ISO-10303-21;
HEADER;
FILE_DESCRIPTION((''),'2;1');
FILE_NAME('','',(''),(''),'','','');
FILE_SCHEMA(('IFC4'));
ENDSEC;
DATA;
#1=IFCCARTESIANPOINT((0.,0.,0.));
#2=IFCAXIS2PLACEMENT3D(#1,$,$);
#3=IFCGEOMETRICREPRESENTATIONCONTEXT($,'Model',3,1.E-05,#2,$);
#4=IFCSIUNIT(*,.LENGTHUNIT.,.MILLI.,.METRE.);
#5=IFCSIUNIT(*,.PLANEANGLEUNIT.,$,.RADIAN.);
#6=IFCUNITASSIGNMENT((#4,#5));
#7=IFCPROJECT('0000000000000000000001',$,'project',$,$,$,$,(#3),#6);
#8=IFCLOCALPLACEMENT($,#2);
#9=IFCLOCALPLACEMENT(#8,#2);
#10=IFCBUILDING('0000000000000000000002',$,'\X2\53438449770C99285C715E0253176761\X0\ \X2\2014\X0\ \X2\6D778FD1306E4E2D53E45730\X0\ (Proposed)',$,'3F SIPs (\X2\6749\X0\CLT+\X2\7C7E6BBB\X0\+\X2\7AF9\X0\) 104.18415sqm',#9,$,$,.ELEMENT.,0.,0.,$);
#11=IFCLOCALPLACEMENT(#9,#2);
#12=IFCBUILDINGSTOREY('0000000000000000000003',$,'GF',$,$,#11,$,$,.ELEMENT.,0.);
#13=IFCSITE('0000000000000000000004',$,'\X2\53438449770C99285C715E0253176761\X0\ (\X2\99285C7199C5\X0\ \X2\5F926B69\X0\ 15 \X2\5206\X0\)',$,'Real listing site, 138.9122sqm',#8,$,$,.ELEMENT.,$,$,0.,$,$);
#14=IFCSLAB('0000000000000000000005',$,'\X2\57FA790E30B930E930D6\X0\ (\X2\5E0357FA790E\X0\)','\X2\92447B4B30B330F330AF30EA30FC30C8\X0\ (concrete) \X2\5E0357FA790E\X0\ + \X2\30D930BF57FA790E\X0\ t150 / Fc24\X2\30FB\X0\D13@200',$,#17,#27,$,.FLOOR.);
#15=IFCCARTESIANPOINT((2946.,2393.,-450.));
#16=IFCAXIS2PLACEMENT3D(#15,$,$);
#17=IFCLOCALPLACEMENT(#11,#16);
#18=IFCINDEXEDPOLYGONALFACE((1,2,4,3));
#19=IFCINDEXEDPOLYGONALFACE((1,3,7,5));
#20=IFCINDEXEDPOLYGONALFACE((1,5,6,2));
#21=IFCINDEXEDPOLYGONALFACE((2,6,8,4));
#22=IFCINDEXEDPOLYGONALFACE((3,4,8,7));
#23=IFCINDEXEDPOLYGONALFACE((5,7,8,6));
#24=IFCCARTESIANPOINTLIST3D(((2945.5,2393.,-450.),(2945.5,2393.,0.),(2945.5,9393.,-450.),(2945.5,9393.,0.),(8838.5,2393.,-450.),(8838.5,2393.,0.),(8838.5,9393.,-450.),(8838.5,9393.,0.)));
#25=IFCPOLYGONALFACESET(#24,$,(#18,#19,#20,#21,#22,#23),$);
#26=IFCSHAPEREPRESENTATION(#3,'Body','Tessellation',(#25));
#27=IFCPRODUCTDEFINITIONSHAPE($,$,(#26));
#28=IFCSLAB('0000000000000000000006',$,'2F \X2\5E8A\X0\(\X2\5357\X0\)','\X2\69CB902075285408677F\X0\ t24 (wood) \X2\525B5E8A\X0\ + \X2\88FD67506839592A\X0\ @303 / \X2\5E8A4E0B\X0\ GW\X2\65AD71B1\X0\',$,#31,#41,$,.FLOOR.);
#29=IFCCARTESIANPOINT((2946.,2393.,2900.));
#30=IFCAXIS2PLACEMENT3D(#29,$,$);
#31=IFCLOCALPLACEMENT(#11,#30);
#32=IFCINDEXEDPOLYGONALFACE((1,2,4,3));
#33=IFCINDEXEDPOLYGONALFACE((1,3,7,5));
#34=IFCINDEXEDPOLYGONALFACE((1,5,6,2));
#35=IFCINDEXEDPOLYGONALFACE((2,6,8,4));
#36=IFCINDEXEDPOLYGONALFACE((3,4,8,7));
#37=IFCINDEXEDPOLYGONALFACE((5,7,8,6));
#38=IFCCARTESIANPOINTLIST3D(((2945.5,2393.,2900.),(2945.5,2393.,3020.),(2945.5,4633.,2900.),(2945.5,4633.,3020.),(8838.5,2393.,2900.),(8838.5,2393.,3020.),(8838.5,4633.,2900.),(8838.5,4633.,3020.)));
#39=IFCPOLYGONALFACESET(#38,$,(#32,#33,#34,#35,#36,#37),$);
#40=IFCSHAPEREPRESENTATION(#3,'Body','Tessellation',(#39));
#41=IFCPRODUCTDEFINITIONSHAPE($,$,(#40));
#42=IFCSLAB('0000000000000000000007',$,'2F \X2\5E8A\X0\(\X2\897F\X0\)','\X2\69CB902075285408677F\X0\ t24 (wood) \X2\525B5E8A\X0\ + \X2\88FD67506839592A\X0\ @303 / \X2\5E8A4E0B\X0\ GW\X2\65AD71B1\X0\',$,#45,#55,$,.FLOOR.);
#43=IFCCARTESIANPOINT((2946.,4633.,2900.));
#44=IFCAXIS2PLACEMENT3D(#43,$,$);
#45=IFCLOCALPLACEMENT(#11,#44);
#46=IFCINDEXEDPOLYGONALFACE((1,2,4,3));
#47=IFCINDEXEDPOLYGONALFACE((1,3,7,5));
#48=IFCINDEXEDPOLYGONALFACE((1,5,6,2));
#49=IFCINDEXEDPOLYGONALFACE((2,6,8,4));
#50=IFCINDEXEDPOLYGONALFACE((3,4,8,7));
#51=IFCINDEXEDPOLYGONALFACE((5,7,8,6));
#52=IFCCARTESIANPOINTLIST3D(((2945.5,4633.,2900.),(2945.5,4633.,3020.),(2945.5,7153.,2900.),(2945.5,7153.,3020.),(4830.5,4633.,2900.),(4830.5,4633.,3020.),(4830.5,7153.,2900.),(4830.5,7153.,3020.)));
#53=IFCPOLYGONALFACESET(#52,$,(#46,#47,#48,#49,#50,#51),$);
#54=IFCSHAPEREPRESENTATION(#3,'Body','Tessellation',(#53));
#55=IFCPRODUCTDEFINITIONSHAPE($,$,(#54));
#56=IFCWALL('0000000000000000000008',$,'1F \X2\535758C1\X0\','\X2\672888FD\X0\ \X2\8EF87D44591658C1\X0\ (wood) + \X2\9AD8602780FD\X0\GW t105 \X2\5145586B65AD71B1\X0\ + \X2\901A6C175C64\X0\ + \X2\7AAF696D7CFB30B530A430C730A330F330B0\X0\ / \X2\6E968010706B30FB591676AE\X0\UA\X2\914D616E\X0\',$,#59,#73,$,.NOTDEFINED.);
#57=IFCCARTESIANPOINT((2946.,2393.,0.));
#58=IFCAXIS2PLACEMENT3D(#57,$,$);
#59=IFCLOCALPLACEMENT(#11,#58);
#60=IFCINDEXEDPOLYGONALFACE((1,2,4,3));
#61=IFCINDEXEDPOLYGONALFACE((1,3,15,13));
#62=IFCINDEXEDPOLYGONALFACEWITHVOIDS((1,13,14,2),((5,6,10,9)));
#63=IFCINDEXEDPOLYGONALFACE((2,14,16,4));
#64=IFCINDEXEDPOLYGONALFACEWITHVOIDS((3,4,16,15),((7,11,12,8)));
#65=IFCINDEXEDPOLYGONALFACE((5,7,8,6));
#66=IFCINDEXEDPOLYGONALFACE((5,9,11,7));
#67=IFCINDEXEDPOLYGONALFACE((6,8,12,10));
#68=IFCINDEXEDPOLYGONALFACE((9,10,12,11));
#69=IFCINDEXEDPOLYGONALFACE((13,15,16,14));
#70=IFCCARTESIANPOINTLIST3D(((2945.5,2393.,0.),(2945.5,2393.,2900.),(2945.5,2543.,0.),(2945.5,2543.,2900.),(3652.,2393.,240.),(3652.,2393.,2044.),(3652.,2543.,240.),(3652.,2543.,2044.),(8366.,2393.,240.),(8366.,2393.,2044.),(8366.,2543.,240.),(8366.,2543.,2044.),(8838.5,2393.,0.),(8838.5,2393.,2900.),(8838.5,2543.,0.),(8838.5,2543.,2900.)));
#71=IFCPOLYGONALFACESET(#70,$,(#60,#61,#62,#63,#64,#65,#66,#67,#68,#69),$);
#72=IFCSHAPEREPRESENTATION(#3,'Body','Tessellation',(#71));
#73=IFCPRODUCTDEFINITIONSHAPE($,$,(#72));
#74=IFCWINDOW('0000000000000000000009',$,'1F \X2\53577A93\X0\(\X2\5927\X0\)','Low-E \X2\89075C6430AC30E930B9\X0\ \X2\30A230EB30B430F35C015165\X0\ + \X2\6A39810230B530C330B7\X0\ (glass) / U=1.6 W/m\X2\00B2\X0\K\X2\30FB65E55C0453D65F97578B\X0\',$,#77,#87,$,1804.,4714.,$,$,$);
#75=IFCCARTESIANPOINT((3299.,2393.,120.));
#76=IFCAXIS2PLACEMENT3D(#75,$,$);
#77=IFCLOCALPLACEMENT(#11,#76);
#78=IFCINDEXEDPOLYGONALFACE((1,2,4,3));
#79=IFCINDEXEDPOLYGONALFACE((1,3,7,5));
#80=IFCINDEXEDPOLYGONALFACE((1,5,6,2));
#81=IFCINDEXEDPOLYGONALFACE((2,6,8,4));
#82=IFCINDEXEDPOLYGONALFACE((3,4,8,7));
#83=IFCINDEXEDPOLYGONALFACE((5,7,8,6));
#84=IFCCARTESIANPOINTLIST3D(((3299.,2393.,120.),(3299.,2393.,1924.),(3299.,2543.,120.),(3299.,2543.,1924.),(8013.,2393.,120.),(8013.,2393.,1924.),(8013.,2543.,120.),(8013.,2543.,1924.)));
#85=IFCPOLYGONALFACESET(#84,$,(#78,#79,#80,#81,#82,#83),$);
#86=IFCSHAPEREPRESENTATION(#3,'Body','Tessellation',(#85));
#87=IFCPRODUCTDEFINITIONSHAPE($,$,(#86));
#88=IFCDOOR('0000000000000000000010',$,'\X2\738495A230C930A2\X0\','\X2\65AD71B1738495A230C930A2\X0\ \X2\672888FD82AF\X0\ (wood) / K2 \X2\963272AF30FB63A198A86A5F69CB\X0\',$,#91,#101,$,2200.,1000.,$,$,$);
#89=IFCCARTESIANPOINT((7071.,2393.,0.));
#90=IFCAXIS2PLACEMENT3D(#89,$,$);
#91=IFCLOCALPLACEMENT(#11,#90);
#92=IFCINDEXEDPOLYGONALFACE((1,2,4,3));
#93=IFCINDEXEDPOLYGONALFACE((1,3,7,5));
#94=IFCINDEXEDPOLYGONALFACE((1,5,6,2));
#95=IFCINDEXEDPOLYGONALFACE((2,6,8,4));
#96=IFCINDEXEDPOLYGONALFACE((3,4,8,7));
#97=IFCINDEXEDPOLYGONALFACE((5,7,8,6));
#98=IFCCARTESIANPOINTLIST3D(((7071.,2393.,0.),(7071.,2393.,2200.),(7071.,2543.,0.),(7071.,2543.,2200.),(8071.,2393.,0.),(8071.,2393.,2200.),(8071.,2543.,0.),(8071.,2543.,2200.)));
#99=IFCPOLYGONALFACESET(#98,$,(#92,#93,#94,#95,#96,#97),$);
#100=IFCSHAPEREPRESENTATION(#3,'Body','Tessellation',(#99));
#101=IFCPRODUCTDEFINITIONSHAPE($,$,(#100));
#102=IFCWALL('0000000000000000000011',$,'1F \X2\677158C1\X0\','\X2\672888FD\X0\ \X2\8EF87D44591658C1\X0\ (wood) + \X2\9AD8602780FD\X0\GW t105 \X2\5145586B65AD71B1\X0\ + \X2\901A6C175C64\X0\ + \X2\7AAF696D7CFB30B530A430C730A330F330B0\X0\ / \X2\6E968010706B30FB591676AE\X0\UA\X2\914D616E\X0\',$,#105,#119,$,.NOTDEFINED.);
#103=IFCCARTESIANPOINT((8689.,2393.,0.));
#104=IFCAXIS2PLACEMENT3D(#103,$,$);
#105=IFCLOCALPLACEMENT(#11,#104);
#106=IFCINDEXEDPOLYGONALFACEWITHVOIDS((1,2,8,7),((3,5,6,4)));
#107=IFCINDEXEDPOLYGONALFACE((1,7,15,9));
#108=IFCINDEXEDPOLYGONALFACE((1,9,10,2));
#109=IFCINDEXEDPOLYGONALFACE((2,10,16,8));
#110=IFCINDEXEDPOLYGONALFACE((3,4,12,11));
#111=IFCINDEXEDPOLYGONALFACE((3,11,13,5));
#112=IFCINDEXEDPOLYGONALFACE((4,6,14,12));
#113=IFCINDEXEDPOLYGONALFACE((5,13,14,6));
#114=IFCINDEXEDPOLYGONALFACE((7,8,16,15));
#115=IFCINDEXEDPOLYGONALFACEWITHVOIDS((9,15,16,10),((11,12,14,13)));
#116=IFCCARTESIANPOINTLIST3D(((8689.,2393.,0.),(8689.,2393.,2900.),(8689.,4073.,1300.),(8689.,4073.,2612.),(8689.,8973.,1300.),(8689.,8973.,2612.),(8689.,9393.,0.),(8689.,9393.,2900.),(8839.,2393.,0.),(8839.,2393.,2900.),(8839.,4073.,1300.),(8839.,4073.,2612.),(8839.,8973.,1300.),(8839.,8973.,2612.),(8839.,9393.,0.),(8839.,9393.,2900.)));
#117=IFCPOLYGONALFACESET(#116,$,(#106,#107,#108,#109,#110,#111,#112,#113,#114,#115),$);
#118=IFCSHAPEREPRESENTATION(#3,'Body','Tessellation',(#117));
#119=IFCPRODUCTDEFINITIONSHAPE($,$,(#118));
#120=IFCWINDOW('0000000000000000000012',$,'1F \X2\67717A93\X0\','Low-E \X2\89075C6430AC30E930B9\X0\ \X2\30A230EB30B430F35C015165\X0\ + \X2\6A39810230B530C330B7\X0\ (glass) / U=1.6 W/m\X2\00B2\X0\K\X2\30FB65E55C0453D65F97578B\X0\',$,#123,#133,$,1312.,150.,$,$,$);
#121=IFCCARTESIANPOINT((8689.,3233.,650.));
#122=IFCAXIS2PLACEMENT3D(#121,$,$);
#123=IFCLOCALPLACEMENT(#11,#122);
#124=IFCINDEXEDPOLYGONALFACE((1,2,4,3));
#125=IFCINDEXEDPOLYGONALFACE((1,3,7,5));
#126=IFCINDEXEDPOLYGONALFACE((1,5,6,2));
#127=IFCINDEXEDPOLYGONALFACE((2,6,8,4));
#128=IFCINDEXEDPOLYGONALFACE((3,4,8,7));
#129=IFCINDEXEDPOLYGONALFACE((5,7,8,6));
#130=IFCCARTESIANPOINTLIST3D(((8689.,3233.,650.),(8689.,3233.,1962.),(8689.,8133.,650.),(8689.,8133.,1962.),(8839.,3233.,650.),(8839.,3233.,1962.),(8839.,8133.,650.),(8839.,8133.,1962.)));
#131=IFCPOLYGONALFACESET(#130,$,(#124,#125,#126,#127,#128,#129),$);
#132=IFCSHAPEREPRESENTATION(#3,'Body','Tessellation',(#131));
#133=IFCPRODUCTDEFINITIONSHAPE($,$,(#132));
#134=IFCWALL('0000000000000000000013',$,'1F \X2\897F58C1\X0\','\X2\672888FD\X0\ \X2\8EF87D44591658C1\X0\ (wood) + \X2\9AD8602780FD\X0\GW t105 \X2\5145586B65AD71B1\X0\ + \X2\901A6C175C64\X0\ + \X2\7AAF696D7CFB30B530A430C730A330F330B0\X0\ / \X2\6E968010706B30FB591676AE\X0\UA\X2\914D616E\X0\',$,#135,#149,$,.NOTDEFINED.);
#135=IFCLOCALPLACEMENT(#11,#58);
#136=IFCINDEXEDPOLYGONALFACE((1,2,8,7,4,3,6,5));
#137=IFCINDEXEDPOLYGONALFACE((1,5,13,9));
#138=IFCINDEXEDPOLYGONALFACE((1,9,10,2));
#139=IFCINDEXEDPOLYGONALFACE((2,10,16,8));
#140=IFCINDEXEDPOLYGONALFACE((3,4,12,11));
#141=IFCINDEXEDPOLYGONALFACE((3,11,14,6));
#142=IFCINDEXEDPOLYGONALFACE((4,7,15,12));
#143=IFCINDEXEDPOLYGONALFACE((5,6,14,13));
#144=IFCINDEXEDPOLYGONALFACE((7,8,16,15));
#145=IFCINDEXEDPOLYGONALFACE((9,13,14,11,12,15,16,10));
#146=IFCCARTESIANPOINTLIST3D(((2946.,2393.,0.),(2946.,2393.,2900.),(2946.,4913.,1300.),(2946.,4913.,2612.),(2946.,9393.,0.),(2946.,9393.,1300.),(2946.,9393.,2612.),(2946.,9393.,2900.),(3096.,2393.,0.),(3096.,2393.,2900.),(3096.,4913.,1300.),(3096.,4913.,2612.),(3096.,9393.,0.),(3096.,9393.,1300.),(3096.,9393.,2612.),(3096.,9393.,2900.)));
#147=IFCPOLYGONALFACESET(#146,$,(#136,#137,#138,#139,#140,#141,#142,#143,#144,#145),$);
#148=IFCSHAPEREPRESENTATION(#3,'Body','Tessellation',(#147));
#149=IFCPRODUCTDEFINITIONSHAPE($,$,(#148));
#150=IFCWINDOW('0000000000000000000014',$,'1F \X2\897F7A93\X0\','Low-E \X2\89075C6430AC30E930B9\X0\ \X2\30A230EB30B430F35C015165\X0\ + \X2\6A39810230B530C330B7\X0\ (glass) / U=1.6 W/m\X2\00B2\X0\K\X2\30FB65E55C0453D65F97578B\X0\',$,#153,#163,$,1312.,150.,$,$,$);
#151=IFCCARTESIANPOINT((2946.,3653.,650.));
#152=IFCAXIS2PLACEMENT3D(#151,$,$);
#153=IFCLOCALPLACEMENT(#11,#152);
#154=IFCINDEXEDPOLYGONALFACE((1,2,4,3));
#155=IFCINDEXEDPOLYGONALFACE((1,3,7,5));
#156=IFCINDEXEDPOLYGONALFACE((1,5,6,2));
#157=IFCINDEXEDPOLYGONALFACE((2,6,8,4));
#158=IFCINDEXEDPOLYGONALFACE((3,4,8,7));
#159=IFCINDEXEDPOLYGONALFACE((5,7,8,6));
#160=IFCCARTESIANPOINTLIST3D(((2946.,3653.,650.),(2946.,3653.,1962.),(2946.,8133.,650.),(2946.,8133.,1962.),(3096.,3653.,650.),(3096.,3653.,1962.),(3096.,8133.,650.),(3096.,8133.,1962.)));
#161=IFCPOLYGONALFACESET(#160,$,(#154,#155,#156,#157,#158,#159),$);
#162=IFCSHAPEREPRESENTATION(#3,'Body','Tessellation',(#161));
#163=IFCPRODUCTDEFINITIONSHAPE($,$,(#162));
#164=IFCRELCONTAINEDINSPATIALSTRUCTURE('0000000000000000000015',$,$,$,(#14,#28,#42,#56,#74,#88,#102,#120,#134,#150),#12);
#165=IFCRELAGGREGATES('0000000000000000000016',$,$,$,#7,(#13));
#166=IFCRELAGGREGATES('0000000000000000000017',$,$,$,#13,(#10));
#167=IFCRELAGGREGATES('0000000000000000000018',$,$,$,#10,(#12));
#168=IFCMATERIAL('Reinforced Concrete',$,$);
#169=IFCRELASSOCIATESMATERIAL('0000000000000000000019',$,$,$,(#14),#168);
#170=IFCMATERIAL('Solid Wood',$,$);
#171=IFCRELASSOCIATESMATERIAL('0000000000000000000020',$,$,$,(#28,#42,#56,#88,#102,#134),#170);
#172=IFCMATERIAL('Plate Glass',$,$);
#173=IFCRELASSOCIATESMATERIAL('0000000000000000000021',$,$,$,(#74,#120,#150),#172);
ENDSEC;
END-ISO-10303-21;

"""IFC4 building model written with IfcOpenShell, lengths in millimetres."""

from ifc_helpers import new_model, si_unit, frame, frame_2d, origin, place, context, project, spatial, rectangle, extrude, material, element, fill, save


model = new_model("IFC4")

# Units and contexts
model_context = context("Model", 3, precision=1e-05, world=origin())
ifc_project = project(units=[si_unit("LENGTHUNIT", "METRE", prefix="MILLI"), si_unit("PLANEANGLEUNIT", "RADIAN")], contexts=[model_context])

# Site, building, storey
site_placement = place(None, origin())
site = spatial("IfcSite", under=ifc_project, at=site_placement, Name="千葉県館山市北条 (館山駅 徒歩 15 分)", ObjectType="Real listing site, 138.9122sqm", CompositionType="ELEMENT", RefElevation=0.0)
building_placement = place(site_placement, origin())
building = spatial("IfcBuilding", under=site, at=building_placement, Name="千葉県館山市北条 — 海近の中古地 (Proposed)", ObjectType="3F SIPs (杉CLT+籾殻+竹) 104.18415sqm", CompositionType="ELEMENT", ElevationOfRefHeight=0.0, ElevationOfTerrain=0.0)
storey_placement = place(building_placement, origin())
storey = spatial("IfcBuildingStorey", under=building, at=storey_placement, Name="GF", CompositionType="ELEMENT", Elevation=0.0)

# Slabs
ifc_material_1 = material(Name="Reinforced Concrete")
slab_1_placement = place(storey_placement, frame((2946.0, 2393.0, -450.0)))
element("IfcSlab", 1, at=slab_1_placement, inside=storey, material=ifc_material_1, Name="基礎スラブ (布基礎)", Description="鉄筋コンクリート (concrete) 布基礎 + ベタ基礎 t150 / Fc24・D13@200", PredefinedType="FLOOR", context=model_context, shape_type="SweptSolid", body=[
    extrude(rectangle(XDim=5893.0, YDim=7000.0, at=frame_2d((2946.0, 3500.0))), frame((2946.0, 2393.0, -450.0)), (0.0, 0.0, 1.0), 450.0),
])
ifc_material_2 = material(Name="Solid Wood")
slab_2_placement = place(storey_placement, frame((2946.0, 2393.0, 2900.0)))
element("IfcSlab", 2, at=slab_2_placement, inside=storey, material=ifc_material_2, Name="2F 床(南)", Description="構造用合板 t24 (wood) 剛床 + 製材根太 @303 / 床下 GW断熱", PredefinedType="FLOOR", context=model_context, shape_type="SweptSolid", body=[
    extrude(rectangle(XDim=5893.0, YDim=2240.0, at=frame_2d((2946.0, 1120.0))), frame((2946.0, 2393.0, 2900.0)), (0.0, 0.0, 1.0), 120.0),
])
slab_3_placement = place(storey_placement, frame((2946.0, 4633.0, 2900.0)))
element("IfcSlab", 3, at=slab_3_placement, inside=storey, material=ifc_material_2, Name="2F 床(西)", Description="構造用合板 t24 (wood) 剛床 + 製材根太 @303 / 床下 GW断熱", PredefinedType="FLOOR", context=model_context, shape_type="SweptSolid", body=[
    extrude(rectangle(XDim=1885.0, YDim=2520.0, at=frame_2d((942.0, 1260.0))), frame((2946.0, 4633.0, 2900.0)), (0.0, 0.0, 1.0), 120.0),
])

# Wall, openings, window, door
wall_1_placement = place(storey_placement, frame((2946.0, 2393.0, 0.0)))
wall_1 = element("IfcWall", 4, at=wall_1_placement, inside=storey, material=ifc_material_2, Name="1F 南壁", Description="木製 軸組外壁 (wood) + 高性能GW t105 充填断熱 + 通気層 + 窯業系サイディング / 準耐火・外皮UA配慮", PredefinedType="NOTDEFINED", context=model_context, shape_type="SweptSolid", body=[
    extrude(rectangle(XDim=5893.0, YDim=150.0, at=frame_2d((2946.0, 75.0))), frame((2946.0, 2393.0, 0.0)), (0.0, 0.0, 1.0), 2900.0),
])
opening_1_placement = place(storey_placement, frame((3299.0, 2393.0, 120.0)))
opening_1 = element("IfcOpeningElement", 5, at=opening_1_placement, cuts=wall_1, PredefinedType="NOTDEFINED", context=model_context, shape_type="SweptSolid", body=[
    extrude(rectangle(XDim=4714.0, YDim=150.0, at=frame_2d((2357.0, 75.0))), frame((3299.0, 2393.0, 120.0)), (0.0, 0.0, 1.0), 1804.0),
])
opening_2_placement = place(storey_placement, frame((7071.0, 2393.0, 0.0)))
opening_2 = element("IfcOpeningElement", 6, at=opening_2_placement, cuts=wall_1, PredefinedType="NOTDEFINED", context=model_context, shape_type="SweptSolid", body=[
    extrude(rectangle(XDim=1000.0, YDim=150.0, at=frame_2d((500.0, 75.0))), frame((7071.0, 2393.0, 0.0)), (0.0, 0.0, 1.0), 2200.0),
])
ifc_material_3 = material(Name="Plate Glass")
window_1_placement = place(storey_placement, frame((3299.0, 2393.0, 120.0)))
window_1 = element("IfcWindow", 7, at=window_1_placement, inside=storey, material=ifc_material_3, Name="1F 南窓(大)", Description="Low-E 複層ガラス アルゴン封入 + 樹脂サッシ (glass) / U=1.6 W/m²K・日射取得型", OverallHeight=1804.0, OverallWidth=4714.0, context=model_context, shape_type="SweptSolid", body=[
    extrude(rectangle(XDim=4714.0, YDim=150.0, at=frame_2d((2357.0, 75.0))), frame((3299.0, 2393.0, 120.0)), (0.0, 0.0, 1.0), 1804.0),
])
fill(opening_1, window_1)
door_placement = place(storey_placement, frame((7071.0, 2393.0, 0.0)))
door = element("IfcDoor", 8, at=door_placement, inside=storey, material=ifc_material_2, Name="玄関ドア", Description="断熱玄関ドア 木製芯 (wood) / K2 防犯・採風機構", OverallHeight=2200.0, OverallWidth=1000.0, context=model_context, shape_type="SweptSolid", body=[
    extrude(rectangle(XDim=1000.0, YDim=150.0, at=frame_2d((500.0, 75.0))), frame((7071.0, 2393.0, 0.0)), (0.0, 0.0, 1.0), 2200.0),
])
fill(opening_2, door)

# Walls, openings, windows
wall_2_placement = place(storey_placement, frame((8689.0, 2393.0, 0.0)))
wall_2 = element("IfcWall", 9, at=wall_2_placement, inside=storey, material=ifc_material_2, Name="1F 東壁", Description="木製 軸組外壁 (wood) + 高性能GW t105 充填断熱 + 通気層 + 窯業系サイディング / 準耐火・外皮UA配慮", PredefinedType="NOTDEFINED", context=model_context, shape_type="SweptSolid", body=[
    extrude(rectangle(XDim=150.0, YDim=7000.0, at=frame_2d((75.0, 3500.0))), frame((8689.0, 2393.0, 0.0)), (0.0, 0.0, 1.0), 2900.0),
])
opening_3_placement = place(storey_placement, frame((8689.0, 3233.0, 650.0)))
opening_3 = element("IfcOpeningElement", 10, at=opening_3_placement, cuts=wall_2, PredefinedType="NOTDEFINED", context=model_context, shape_type="SweptSolid", body=[
    extrude(rectangle(XDim=150.0, YDim=4900.0, at=frame_2d((75.0, 2450.0))), frame((8689.0, 3233.0, 650.0)), (0.0, 0.0, 1.0), 1312.0),
])
window_2_placement = place(storey_placement, frame((8689.0, 3233.0, 650.0)))
window_2 = element("IfcWindow", 11, at=window_2_placement, inside=storey, material=ifc_material_3, Name="1F 東窓", Description="Low-E 複層ガラス アルゴン封入 + 樹脂サッシ (glass) / U=1.6 W/m²K・日射取得型", OverallHeight=1312.0, OverallWidth=150.0, context=model_context, shape_type="SweptSolid", body=[
    extrude(rectangle(XDim=150.0, YDim=4900.0, at=frame_2d((75.0, 2450.0))), frame((8689.0, 3233.0, 650.0)), (0.0, 0.0, 1.0), 1312.0),
])
fill(opening_3, window_2)
wall_3_placement = place(storey_placement, frame((2946.0, 2393.0, 0.0)))
wall_3 = element("IfcWall", 12, at=wall_3_placement, inside=storey, material=ifc_material_2, Name="1F 西壁", Description="木製 軸組外壁 (wood) + 高性能GW t105 充填断熱 + 通気層 + 窯業系サイディング / 準耐火・外皮UA配慮", PredefinedType="NOTDEFINED", context=model_context, shape_type="SweptSolid", body=[
    extrude(rectangle(XDim=150.0, YDim=7000.0, at=frame_2d((75.0, 3500.0))), frame((2946.0, 2393.0, 0.0)), (0.0, 0.0, 1.0), 2900.0),
])
opening_4_placement = place(storey_placement, frame((2946.0, 3653.0, 650.0)))
opening_4 = element("IfcOpeningElement", 13, at=opening_4_placement, cuts=wall_3, PredefinedType="NOTDEFINED", context=model_context, shape_type="SweptSolid", body=[
    extrude(rectangle(XDim=150.0, YDim=4480.0, at=frame_2d((75.0, 2240.0))), frame((2946.0, 3653.0, 650.0)), (0.0, 0.0, 1.0), 1312.0),
])
window_3_placement = place(storey_placement, frame((2946.0, 3653.0, 650.0)))
window_3 = element("IfcWindow", 14, at=window_3_placement, inside=storey, material=ifc_material_3, Name="1F 西窓", Description="Low-E 複層ガラス アルゴン封入 + 樹脂サッシ (glass) / U=1.6 W/m²K・日射取得型", OverallHeight=1312.0, OverallWidth=150.0, context=model_context, shape_type="SweptSolid", body=[
    extrude(rectangle(XDim=150.0, YDim=4480.0, at=frame_2d((75.0, 2240.0))), frame((2946.0, 3653.0, 650.0)), (0.0, 0.0, 1.0), 1312.0),
])
fill(opening_4, window_3)

save(model, "model.ifc")
